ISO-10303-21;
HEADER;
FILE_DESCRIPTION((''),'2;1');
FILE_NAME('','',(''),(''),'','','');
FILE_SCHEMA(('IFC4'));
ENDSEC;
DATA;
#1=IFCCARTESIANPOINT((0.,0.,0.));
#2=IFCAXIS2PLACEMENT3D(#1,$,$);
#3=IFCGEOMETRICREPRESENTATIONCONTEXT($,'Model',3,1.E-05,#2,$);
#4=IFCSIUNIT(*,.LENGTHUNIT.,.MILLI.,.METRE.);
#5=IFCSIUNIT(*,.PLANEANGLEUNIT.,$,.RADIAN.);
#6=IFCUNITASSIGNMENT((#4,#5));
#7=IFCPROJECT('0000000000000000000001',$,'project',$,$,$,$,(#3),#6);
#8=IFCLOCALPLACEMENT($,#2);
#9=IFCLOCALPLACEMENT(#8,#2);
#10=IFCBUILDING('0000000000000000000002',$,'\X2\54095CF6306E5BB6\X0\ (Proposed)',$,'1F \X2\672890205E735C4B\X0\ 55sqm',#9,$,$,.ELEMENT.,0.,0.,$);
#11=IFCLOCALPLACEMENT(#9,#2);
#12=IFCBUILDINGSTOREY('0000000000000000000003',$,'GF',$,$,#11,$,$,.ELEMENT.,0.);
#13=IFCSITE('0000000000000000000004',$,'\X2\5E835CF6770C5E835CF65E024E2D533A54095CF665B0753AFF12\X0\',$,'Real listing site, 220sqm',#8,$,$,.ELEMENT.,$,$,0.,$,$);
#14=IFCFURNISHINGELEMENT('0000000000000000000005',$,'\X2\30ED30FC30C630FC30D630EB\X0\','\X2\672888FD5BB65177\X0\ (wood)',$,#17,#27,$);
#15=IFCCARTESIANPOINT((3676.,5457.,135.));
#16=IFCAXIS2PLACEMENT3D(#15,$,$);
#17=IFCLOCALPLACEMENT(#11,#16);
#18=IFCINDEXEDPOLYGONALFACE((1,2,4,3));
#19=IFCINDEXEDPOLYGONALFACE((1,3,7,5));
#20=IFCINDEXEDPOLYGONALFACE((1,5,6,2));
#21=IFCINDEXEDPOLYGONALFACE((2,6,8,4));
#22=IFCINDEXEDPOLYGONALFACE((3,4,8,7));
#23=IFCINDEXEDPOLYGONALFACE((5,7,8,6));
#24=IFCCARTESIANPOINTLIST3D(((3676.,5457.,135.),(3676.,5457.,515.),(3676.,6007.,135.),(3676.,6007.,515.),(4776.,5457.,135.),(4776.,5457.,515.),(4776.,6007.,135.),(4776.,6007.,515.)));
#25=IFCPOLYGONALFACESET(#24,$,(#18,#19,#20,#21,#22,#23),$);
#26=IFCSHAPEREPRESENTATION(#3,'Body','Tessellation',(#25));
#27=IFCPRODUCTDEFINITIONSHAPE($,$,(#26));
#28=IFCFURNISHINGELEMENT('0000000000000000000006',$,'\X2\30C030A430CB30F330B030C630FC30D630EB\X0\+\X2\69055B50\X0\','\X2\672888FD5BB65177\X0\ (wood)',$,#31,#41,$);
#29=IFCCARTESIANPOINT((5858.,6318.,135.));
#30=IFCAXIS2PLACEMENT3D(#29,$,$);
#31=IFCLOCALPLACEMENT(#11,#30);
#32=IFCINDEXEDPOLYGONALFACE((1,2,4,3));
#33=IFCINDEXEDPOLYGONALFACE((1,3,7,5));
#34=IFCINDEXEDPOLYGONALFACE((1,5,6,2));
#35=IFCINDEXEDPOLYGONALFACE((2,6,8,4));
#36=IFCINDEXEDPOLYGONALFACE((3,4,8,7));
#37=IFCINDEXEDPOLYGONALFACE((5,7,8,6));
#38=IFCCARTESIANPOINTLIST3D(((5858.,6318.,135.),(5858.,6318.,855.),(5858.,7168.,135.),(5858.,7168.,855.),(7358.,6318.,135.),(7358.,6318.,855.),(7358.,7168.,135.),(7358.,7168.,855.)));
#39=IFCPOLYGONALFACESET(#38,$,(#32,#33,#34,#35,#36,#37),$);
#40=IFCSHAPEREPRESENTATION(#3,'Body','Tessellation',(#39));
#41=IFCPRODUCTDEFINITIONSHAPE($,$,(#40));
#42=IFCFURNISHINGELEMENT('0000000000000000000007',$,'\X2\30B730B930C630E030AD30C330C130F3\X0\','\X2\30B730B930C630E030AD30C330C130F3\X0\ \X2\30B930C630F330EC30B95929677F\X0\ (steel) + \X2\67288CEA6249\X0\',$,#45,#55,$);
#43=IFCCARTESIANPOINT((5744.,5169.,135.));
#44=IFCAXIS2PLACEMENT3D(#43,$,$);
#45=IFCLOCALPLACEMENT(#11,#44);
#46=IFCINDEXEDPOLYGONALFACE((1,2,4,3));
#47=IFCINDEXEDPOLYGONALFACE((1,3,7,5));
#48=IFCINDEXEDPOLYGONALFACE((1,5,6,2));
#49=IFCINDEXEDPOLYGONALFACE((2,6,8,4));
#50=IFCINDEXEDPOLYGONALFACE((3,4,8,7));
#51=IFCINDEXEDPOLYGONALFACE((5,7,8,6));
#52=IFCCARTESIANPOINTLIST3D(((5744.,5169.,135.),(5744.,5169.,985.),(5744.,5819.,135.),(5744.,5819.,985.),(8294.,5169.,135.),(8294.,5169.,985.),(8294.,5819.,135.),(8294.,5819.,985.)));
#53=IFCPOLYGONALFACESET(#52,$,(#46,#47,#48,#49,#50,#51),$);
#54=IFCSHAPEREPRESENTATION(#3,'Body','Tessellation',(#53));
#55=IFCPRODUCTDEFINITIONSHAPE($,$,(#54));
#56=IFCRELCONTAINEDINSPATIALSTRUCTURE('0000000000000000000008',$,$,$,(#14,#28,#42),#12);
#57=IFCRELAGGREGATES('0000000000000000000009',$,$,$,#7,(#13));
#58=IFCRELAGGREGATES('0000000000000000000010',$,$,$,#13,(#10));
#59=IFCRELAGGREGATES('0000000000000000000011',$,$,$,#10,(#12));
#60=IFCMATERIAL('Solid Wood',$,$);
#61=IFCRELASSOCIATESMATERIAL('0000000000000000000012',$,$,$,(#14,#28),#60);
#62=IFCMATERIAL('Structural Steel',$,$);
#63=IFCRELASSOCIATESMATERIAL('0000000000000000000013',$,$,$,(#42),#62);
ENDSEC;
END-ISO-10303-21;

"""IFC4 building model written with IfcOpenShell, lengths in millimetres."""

from ifc_helpers import new_model, si_unit, frame, frame_2d, origin, place, context, project, spatial, rectangle, extrude, material, element, save


model = new_model("IFC4")

# Units and contexts
model_context = context("Model", 3, precision=1e-05, world=origin())
ifc_project = project(units=[si_unit("LENGTHUNIT", "METRE", prefix="MILLI"), si_unit("PLANEANGLEUNIT", "RADIAN")], contexts=[model_context])

# Site, building, storey
site_placement = place(None, origin())
site = spatial("IfcSite", under=ifc_project, at=site_placement, Name="広島県広島市中区吉島新町２", ObjectType="Real listing site, 220sqm", CompositionType="ELEMENT", RefElevation=0.0)
building_placement = place(site_placement, origin())
building = spatial("IfcBuilding", under=site, at=building_placement, Name="吉島の家 (Proposed)", ObjectType="1F 木造平屋 55sqm", CompositionType="ELEMENT", ElevationOfRefHeight=0.0, ElevationOfTerrain=0.0)
storey_placement = place(building_placement, origin())
storey = spatial("IfcBuildingStorey", under=building, at=storey_placement, Name="GF", CompositionType="ELEMENT", Elevation=0.0)

# Shared definitions
ifc_material_1 = material(Name="Solid Wood")

# Shared definitions
ifc_material_2 = material(Name="Structural Steel")

# Furnishing elements
furnishing_1_placement = place(storey_placement, frame((3676.0, 5457.0, 135.0)))
element("IfcFurnishingElement", 1, at=furnishing_1_placement, inside=storey, material=ifc_material_1, Name="ローテーブル", Description="木製家具 (wood)", context=model_context, shape_type="SweptSolid", body=[
    extrude(rectangle(XDim=1100.0, YDim=550.0, at=frame_2d((550.0, 275.0))), frame((3676.0, 5457.0, 135.0)), (0.0, 0.0, 1.0), 380.0),
])
furnishing_2_placement = place(storey_placement, frame((5858.0, 6318.0, 135.0)))
element("IfcFurnishingElement", 2, at=furnishing_2_placement, inside=storey, material=ifc_material_1, Name="ダイニングテーブル+椅子", Description="木製家具 (wood)", context=model_context, shape_type="SweptSolid", body=[
    extrude(rectangle(XDim=1500.0, YDim=850.0, at=frame_2d((750.0, 425.0))), frame((5858.0, 6318.0, 135.0)), (0.0, 0.0, 1.0), 720.0),
])
furnishing_3_placement = place(storey_placement, frame((5744.0, 5169.0, 135.0)))
element("IfcFurnishingElement", 3, at=furnishing_3_placement, inside=storey, material=ifc_material_2, Name="システムキッチン", Description="システムキッチン ステンレス天板 (steel) + 木質扉", context=model_context, shape_type="SweptSolid", body=[
    extrude(rectangle(XDim=2550.0, YDim=650.0, at=frame_2d((1275.0, 325.0))), frame((5744.0, 5169.0, 135.0)), (0.0, 0.0, 1.0), 850.0),
])

save(model, "model.ifc")
